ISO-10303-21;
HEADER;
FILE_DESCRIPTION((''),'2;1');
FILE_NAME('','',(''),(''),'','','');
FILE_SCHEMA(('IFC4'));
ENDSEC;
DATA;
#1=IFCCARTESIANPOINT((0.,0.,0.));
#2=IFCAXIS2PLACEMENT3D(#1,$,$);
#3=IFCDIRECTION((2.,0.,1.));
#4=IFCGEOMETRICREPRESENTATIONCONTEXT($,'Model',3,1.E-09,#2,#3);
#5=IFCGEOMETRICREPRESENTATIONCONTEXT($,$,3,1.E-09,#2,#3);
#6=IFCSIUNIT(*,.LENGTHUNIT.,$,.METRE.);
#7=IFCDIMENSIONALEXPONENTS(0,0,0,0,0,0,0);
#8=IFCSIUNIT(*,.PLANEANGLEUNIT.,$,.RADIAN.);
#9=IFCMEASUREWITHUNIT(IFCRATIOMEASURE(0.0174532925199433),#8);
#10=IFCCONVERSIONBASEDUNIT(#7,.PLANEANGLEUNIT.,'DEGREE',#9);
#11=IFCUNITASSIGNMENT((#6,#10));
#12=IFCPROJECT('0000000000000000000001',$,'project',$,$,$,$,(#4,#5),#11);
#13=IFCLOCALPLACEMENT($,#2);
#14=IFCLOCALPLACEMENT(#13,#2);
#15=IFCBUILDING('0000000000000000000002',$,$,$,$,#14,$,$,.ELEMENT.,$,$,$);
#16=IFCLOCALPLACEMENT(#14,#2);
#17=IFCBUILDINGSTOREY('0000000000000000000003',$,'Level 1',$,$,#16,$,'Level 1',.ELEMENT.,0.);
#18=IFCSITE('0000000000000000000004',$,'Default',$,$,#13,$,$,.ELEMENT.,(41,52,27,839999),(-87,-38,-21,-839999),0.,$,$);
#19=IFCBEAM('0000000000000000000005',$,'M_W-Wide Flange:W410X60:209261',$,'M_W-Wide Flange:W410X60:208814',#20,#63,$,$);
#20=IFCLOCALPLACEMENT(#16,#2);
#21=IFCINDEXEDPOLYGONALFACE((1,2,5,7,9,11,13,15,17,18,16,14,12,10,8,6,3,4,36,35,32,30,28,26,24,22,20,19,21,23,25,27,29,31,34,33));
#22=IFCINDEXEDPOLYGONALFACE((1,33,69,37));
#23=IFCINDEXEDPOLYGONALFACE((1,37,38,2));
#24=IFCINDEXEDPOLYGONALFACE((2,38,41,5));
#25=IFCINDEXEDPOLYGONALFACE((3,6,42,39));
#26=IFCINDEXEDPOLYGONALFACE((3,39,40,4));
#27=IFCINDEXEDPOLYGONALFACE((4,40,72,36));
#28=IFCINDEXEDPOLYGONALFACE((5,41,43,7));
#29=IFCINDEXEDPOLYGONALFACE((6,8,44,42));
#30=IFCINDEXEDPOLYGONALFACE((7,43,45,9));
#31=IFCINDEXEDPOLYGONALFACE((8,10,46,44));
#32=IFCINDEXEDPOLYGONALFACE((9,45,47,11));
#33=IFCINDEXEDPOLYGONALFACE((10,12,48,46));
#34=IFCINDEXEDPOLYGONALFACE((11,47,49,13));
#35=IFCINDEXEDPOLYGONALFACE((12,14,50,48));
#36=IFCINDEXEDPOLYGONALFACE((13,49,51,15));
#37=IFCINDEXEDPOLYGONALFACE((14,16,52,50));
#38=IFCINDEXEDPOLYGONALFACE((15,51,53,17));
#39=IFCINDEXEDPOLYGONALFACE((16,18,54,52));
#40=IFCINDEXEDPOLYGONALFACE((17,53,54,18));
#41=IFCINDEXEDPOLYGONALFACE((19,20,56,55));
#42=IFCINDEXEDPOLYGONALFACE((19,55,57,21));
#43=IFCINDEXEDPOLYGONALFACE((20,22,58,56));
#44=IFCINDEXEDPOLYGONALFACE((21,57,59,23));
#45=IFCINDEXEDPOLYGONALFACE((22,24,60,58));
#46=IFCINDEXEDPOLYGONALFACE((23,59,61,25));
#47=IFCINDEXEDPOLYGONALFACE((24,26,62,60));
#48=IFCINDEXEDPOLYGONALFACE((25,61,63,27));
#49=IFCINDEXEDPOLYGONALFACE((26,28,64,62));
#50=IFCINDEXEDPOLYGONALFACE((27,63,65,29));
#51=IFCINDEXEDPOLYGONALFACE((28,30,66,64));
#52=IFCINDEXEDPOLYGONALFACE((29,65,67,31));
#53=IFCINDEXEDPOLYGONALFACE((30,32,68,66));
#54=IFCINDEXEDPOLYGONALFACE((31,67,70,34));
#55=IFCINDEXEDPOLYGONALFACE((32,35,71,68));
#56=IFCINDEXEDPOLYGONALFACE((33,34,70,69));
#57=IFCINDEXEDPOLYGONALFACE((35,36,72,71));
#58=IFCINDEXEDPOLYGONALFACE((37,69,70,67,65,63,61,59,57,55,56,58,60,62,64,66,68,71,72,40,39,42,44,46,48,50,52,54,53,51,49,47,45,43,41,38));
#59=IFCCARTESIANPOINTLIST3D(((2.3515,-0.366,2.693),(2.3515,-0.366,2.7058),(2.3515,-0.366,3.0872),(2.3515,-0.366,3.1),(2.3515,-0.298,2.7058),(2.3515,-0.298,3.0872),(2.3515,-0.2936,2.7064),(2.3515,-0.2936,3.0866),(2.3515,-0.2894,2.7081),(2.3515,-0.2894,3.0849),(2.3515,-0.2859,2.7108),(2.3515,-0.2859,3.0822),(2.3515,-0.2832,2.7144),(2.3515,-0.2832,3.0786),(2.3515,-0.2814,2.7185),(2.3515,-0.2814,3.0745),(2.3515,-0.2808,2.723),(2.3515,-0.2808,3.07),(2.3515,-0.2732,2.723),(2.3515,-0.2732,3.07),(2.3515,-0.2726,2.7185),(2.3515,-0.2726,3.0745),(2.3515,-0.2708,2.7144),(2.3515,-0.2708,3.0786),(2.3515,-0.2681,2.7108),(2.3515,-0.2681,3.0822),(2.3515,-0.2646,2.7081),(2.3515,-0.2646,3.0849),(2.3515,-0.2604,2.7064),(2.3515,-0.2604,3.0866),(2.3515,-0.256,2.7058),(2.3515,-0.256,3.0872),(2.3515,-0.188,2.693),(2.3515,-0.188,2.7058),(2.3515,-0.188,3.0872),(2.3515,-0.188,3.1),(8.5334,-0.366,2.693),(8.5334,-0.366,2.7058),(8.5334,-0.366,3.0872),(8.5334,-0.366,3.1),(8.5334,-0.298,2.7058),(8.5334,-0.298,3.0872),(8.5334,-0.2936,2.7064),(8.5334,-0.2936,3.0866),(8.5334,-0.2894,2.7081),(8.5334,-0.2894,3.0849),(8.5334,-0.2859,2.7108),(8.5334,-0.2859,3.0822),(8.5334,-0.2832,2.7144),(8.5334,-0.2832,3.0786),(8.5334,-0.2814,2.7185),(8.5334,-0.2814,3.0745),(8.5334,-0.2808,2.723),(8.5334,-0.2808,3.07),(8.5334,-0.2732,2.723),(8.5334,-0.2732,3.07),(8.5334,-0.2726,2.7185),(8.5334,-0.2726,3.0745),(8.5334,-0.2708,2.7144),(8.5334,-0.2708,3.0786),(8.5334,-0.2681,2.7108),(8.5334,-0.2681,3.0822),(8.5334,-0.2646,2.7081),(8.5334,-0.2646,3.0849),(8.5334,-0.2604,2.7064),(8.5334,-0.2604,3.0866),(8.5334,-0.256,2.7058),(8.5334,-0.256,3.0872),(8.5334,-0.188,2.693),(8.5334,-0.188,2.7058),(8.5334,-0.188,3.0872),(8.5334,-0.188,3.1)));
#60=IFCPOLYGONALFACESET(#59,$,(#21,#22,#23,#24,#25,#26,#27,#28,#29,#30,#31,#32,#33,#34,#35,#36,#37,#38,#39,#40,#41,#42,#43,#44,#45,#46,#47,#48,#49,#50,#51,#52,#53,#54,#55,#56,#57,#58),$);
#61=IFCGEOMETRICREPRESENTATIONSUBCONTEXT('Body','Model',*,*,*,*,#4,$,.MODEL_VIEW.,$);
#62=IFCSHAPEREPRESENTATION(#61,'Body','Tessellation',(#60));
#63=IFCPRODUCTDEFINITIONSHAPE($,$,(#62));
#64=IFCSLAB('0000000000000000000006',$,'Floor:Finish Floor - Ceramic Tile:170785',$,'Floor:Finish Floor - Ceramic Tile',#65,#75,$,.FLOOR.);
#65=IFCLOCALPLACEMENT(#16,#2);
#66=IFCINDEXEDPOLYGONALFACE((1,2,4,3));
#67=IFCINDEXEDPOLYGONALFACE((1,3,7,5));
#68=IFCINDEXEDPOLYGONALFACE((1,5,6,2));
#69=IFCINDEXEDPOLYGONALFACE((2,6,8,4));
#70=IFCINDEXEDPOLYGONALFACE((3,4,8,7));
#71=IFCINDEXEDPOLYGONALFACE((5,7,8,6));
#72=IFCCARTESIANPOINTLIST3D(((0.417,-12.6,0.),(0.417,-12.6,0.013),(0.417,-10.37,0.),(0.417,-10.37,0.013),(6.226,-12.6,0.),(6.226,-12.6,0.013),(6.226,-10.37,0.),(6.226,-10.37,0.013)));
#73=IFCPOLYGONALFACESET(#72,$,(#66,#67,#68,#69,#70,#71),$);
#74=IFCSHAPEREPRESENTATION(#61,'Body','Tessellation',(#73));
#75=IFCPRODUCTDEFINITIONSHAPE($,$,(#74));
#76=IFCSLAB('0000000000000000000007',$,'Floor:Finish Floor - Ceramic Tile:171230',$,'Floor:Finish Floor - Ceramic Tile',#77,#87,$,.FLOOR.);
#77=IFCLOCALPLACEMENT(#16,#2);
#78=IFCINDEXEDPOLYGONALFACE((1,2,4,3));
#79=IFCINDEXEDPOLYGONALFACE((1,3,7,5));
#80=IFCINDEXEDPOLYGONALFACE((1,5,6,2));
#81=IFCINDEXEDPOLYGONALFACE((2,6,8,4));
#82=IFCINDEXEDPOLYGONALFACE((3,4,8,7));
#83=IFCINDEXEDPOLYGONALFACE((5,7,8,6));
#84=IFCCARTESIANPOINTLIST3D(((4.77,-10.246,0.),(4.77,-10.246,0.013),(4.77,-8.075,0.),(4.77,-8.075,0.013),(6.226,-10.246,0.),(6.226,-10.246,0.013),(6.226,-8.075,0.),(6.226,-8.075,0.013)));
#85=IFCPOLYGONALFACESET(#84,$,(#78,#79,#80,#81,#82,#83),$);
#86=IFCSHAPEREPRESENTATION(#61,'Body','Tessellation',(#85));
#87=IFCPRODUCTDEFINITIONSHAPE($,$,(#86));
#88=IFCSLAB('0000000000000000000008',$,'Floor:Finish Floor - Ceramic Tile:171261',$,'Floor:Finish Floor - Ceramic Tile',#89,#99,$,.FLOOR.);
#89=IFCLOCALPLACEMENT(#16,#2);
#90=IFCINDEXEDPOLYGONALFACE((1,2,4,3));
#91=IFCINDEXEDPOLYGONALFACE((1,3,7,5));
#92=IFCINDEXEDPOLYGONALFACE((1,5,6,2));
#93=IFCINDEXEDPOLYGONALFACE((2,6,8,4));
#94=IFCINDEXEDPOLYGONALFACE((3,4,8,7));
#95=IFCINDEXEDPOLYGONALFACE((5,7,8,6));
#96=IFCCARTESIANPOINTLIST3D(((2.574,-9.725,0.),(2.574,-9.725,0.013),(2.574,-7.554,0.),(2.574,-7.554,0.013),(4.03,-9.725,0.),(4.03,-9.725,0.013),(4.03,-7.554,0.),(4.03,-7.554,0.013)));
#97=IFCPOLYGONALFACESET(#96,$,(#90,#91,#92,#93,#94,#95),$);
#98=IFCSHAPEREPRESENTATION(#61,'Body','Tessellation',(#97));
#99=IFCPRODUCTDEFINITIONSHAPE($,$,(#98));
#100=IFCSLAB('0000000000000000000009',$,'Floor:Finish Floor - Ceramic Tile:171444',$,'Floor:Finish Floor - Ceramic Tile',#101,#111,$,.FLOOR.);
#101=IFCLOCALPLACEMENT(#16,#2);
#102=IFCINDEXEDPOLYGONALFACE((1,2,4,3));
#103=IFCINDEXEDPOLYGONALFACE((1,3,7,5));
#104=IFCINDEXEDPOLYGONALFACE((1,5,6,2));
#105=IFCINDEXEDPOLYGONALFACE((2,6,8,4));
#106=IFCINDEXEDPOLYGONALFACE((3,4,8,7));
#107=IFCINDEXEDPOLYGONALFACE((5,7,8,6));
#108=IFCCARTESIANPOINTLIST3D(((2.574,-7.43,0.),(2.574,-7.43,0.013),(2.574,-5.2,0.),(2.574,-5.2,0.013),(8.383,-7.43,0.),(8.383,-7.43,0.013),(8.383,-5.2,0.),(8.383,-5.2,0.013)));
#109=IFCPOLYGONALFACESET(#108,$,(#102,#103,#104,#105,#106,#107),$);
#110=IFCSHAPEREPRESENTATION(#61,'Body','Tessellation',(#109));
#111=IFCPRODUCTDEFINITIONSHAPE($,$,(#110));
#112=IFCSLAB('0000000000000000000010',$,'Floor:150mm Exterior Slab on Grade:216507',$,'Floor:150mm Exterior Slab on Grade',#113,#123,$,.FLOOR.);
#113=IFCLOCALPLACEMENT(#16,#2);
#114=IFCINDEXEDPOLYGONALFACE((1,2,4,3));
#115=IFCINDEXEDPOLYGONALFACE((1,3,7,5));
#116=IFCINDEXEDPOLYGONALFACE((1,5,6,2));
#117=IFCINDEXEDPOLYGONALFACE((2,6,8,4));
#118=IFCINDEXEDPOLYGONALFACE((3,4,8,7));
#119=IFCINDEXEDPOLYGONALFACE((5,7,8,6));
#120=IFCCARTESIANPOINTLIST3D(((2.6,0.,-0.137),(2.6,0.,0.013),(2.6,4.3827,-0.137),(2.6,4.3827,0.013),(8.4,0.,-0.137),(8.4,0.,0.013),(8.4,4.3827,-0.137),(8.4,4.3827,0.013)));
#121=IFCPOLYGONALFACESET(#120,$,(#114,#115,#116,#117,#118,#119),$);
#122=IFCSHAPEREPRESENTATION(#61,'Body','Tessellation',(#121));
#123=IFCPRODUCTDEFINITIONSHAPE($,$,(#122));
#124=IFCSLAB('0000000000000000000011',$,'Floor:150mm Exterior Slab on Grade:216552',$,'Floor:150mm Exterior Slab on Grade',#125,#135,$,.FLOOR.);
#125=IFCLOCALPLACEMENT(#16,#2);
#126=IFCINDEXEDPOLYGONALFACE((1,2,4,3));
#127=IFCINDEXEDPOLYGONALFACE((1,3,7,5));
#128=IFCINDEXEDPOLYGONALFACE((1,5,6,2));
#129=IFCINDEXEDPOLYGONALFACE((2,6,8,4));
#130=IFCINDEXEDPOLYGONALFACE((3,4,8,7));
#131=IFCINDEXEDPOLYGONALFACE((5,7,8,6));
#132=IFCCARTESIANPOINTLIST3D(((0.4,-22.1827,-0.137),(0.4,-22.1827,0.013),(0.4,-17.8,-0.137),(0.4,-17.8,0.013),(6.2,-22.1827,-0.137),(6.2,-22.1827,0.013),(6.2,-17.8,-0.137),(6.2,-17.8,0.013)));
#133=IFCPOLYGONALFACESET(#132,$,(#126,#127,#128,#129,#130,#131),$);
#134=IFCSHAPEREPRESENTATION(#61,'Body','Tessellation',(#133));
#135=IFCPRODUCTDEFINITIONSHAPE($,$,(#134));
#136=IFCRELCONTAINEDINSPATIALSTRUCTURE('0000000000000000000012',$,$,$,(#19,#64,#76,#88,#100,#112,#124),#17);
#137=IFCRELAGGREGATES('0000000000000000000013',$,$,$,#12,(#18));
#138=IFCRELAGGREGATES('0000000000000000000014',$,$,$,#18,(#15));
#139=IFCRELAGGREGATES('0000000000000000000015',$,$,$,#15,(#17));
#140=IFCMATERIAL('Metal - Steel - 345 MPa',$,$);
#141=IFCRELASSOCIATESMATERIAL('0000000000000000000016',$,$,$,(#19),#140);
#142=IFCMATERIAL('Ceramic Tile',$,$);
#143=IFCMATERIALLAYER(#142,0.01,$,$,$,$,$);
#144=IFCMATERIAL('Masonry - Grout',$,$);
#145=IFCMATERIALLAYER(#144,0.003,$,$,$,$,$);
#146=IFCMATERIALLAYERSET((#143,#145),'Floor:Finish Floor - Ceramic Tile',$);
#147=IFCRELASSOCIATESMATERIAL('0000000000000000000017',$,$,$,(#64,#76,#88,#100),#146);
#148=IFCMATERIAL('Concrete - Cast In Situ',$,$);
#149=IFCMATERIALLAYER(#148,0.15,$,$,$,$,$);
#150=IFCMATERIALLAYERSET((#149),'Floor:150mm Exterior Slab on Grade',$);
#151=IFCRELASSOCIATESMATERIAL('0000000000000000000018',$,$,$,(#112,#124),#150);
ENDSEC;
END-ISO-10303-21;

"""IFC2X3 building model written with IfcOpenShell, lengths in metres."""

from ifc_helpers import new_model, entity, si_unit, converted_unit, direction, frame, frame_2d, origin, place, context, subcontext, project, spatial, rectangle, i_section, extrude, material, layer, layer_set, layer_usage, element, save


model = new_model("IFC2X3")

# Units and contexts
model_context = context("Model", 3, precision=1e-09, world=origin(), true_north=direction((2.0, 0.0, 1.0)))
context_of_model = context(None, 3, precision=1e-09, world=origin(), true_north=direction((2.0, 0.0, 1.0)))
body_context = subcontext(model_context, "Body", "Model", "MODEL_VIEW")
ifc_project = project(units=[si_unit("LENGTHUNIT", "METRE"), converted_unit("PLANEANGLEUNIT", "DEGREE", entity("IfcRatioMeasure", 0.0174532925199433), si_unit("PLANEANGLEUNIT", "RADIAN"), dimensions=[0, 0, 0, 0, 0, 0, 0])], contexts=[model_context, context_of_model])

# Site, building, storey
site_placement = place(None, origin())
site = spatial("IfcSite", under=ifc_project, at=site_placement, Name="Default", CompositionType="ELEMENT", RefLatitude=(41, 52, 27, 839999), RefLongitude=(-87, -38, -21, -839999), RefElevation=0.0)
building_placement = place(site_placement, origin())
building = spatial("IfcBuilding", under=site, at=building_placement, CompositionType="ELEMENT")
storey_placement = place(building_placement, origin())
storey = spatial("IfcBuildingStorey", under=building, at=storey_placement, Name="Level 1", LongName="Level 1", CompositionType="ELEMENT", Elevation=0.0)

# Beam
ifc_material_1 = material(Name="Metal - Steel - 345 MPa")
beam_placement = place(storey_placement, frame((8.5334, -0.277, 3.1), z_axis=(0.0, 0.0, 1.0), x_axis=(-1.0, 0.0, 0.0)))
element("IfcBeam", 1, at=beam_placement, inside=storey, material=ifc_material_1, Name="M_W-Wide Flange:W410X60:209261", ObjectType="M_W-Wide Flange:W410X60:208814", context=body_context, shape_type="SweptSolid", body=[
    extrude(i_section(OverallWidth=0.178, OverallDepth=0.407, WebThickness=0.0077, FlangeThickness=0.0128, FilletRadius=0.0172, at=frame_2d((0.0, 0.0), x_axis=(0.0, 1.0))), frame((0.0, 0.0, -0.2035), z_axis=(1.0, 0.0, 0.0), x_axis=(0.0, 0.0, -1.0)), (0.0, 0.0, 1.0), 6.1819),
])

# Slabs
ifc_material_2 = material(Name="Ceramic Tile")
ifc_layer_1 = layer(ifc_material_2, 0.01)
ifc_material_3 = material(Name="Masonry - Grout")
ifc_layer_2 = layer(ifc_material_3, 0.003)
ifc_layer_set_1 = layer_set([ifc_layer_1, ifc_layer_2], Name="Floor:Finish Floor - Ceramic Tile")
ifc_layer_usage_1 = layer_usage(ifc_layer_set_1, "AXIS3", "POSITIVE", 0.0)
slab_1_placement = place(storey_placement, origin())
element("IfcSlab", 2, at=slab_1_placement, inside=storey, material=ifc_layer_usage_1, Name="Floor:Finish Floor - Ceramic Tile:170785", ObjectType="Floor:Finish Floor - Ceramic Tile", PredefinedType="FLOOR", context=body_context, shape_type="SweptSolid", body=[
    extrude(rectangle(XDim=2.23, YDim=5.809, at=frame_2d((0.0, 0.0), x_axis=(1.0, 0.0))), frame((3.3215, -11.485, 0.013), z_axis=(0.0, 0.0, -1.0), x_axis=(0.0, 1.0, 0.0)), (0.0, 0.0, 1.0), 0.013),
])
ifc_layer_usage_2 = layer_usage(ifc_layer_set_1, "AXIS3", "POSITIVE", 0.0)
slab_2_placement = place(storey_placement, origin())
element("IfcSlab", 3, at=slab_2_placement, inside=storey, material=ifc_layer_usage_2, Name="Floor:Finish Floor - Ceramic Tile:171230", ObjectType="Floor:Finish Floor - Ceramic Tile", PredefinedType="FLOOR", context=body_context, shape_type="SweptSolid", body=[
    extrude(rectangle(XDim=2.171, YDim=1.456, at=frame_2d((0.0, 0.0), x_axis=(1.0, 0.0))), frame((5.498, -9.1605, 0.013), z_axis=(0.0, 0.0, -1.0), x_axis=(0.0, 1.0, 0.0)), (0.0, 0.0, 1.0), 0.013),
])
ifc_layer_usage_3 = layer_usage(ifc_layer_set_1, "AXIS3", "POSITIVE", 0.0)
slab_3_placement = place(storey_placement, origin())
element("IfcSlab", 4, at=slab_3_placement, inside=storey, material=ifc_layer_usage_3, Name="Floor:Finish Floor - Ceramic Tile:171261", ObjectType="Floor:Finish Floor - Ceramic Tile", PredefinedType="FLOOR", context=body_context, shape_type="SweptSolid", body=[
    extrude(rectangle(XDim=2.171, YDim=1.456, at=frame_2d((0.0, 0.0), x_axis=(1.0, 0.0))), frame((3.302, -8.6395, 0.013), z_axis=(0.0, 0.0, -1.0), x_axis=(0.0, 1.0, 0.0)), (0.0, 0.0, 1.0), 0.013),
])
ifc_layer_usage_4 = layer_usage(ifc_layer_set_1, "AXIS3", "POSITIVE", 0.0)
slab_4_placement = place(storey_placement, origin())
element("IfcSlab", 5, at=slab_4_placement, inside=storey, material=ifc_layer_usage_4, Name="Floor:Finish Floor - Ceramic Tile:171444", ObjectType="Floor:Finish Floor - Ceramic Tile", PredefinedType="FLOOR", context=body_context, shape_type="SweptSolid", body=[
    extrude(rectangle(XDim=2.23, YDim=5.809, at=frame_2d((0.0, 0.0), x_axis=(1.0, 0.0))), frame((5.4785, -6.315, 0.013), z_axis=(0.0, 0.0, -1.0), x_axis=(0.0, 1.0, 0.0)), (0.0, 0.0, 1.0), 0.013),
])
ifc_material_4 = material(Name="Concrete - Cast In Situ")
ifc_layer_3 = layer(ifc_material_4, 0.15)
ifc_layer_set_2 = layer_set([ifc_layer_3], Name="Floor:150mm Exterior Slab on Grade")
ifc_layer_usage_5 = layer_usage(ifc_layer_set_2, "AXIS3", "POSITIVE", 0.0)
slab_5_placement = place(storey_placement, origin())
element("IfcSlab", 6, at=slab_5_placement, inside=storey, material=ifc_layer_usage_5, Name="Floor:150mm Exterior Slab on Grade:216507", ObjectType="Floor:150mm Exterior Slab on Grade", PredefinedType="FLOOR", context=body_context, shape_type="SweptSolid", body=[
    extrude(rectangle(XDim=4.3827, YDim=5.8, at=frame_2d((0.0, 0.0), x_axis=(1.0, 0.0))), frame((5.5, 2.1914, 0.013), z_axis=(0.0, 0.0, -1.0), x_axis=(0.0, 1.0, 0.0)), (0.0, 0.0, 1.0), 0.15),
])
ifc_layer_usage_6 = layer_usage(ifc_layer_set_2, "AXIS3", "POSITIVE", 0.0)
slab_6_placement = place(storey_placement, origin())
element("IfcSlab", 7, at=slab_6_placement, inside=storey, material=ifc_layer_usage_6, Name="Floor:150mm Exterior Slab on Grade:216552", ObjectType="Floor:150mm Exterior Slab on Grade", PredefinedType="FLOOR", context=body_context, shape_type="SweptSolid", body=[
    extrude(rectangle(XDim=4.3827, YDim=5.8, at=frame_2d((0.0, 0.0), x_axis=(1.0, 0.0))), frame((3.3, -19.9914, 0.013), z_axis=(0.0, 0.0, -1.0), x_axis=(0.0, 1.0, 0.0)), (0.0, 0.0, 1.0), 0.15),
])

save(model, "model.ifc")
